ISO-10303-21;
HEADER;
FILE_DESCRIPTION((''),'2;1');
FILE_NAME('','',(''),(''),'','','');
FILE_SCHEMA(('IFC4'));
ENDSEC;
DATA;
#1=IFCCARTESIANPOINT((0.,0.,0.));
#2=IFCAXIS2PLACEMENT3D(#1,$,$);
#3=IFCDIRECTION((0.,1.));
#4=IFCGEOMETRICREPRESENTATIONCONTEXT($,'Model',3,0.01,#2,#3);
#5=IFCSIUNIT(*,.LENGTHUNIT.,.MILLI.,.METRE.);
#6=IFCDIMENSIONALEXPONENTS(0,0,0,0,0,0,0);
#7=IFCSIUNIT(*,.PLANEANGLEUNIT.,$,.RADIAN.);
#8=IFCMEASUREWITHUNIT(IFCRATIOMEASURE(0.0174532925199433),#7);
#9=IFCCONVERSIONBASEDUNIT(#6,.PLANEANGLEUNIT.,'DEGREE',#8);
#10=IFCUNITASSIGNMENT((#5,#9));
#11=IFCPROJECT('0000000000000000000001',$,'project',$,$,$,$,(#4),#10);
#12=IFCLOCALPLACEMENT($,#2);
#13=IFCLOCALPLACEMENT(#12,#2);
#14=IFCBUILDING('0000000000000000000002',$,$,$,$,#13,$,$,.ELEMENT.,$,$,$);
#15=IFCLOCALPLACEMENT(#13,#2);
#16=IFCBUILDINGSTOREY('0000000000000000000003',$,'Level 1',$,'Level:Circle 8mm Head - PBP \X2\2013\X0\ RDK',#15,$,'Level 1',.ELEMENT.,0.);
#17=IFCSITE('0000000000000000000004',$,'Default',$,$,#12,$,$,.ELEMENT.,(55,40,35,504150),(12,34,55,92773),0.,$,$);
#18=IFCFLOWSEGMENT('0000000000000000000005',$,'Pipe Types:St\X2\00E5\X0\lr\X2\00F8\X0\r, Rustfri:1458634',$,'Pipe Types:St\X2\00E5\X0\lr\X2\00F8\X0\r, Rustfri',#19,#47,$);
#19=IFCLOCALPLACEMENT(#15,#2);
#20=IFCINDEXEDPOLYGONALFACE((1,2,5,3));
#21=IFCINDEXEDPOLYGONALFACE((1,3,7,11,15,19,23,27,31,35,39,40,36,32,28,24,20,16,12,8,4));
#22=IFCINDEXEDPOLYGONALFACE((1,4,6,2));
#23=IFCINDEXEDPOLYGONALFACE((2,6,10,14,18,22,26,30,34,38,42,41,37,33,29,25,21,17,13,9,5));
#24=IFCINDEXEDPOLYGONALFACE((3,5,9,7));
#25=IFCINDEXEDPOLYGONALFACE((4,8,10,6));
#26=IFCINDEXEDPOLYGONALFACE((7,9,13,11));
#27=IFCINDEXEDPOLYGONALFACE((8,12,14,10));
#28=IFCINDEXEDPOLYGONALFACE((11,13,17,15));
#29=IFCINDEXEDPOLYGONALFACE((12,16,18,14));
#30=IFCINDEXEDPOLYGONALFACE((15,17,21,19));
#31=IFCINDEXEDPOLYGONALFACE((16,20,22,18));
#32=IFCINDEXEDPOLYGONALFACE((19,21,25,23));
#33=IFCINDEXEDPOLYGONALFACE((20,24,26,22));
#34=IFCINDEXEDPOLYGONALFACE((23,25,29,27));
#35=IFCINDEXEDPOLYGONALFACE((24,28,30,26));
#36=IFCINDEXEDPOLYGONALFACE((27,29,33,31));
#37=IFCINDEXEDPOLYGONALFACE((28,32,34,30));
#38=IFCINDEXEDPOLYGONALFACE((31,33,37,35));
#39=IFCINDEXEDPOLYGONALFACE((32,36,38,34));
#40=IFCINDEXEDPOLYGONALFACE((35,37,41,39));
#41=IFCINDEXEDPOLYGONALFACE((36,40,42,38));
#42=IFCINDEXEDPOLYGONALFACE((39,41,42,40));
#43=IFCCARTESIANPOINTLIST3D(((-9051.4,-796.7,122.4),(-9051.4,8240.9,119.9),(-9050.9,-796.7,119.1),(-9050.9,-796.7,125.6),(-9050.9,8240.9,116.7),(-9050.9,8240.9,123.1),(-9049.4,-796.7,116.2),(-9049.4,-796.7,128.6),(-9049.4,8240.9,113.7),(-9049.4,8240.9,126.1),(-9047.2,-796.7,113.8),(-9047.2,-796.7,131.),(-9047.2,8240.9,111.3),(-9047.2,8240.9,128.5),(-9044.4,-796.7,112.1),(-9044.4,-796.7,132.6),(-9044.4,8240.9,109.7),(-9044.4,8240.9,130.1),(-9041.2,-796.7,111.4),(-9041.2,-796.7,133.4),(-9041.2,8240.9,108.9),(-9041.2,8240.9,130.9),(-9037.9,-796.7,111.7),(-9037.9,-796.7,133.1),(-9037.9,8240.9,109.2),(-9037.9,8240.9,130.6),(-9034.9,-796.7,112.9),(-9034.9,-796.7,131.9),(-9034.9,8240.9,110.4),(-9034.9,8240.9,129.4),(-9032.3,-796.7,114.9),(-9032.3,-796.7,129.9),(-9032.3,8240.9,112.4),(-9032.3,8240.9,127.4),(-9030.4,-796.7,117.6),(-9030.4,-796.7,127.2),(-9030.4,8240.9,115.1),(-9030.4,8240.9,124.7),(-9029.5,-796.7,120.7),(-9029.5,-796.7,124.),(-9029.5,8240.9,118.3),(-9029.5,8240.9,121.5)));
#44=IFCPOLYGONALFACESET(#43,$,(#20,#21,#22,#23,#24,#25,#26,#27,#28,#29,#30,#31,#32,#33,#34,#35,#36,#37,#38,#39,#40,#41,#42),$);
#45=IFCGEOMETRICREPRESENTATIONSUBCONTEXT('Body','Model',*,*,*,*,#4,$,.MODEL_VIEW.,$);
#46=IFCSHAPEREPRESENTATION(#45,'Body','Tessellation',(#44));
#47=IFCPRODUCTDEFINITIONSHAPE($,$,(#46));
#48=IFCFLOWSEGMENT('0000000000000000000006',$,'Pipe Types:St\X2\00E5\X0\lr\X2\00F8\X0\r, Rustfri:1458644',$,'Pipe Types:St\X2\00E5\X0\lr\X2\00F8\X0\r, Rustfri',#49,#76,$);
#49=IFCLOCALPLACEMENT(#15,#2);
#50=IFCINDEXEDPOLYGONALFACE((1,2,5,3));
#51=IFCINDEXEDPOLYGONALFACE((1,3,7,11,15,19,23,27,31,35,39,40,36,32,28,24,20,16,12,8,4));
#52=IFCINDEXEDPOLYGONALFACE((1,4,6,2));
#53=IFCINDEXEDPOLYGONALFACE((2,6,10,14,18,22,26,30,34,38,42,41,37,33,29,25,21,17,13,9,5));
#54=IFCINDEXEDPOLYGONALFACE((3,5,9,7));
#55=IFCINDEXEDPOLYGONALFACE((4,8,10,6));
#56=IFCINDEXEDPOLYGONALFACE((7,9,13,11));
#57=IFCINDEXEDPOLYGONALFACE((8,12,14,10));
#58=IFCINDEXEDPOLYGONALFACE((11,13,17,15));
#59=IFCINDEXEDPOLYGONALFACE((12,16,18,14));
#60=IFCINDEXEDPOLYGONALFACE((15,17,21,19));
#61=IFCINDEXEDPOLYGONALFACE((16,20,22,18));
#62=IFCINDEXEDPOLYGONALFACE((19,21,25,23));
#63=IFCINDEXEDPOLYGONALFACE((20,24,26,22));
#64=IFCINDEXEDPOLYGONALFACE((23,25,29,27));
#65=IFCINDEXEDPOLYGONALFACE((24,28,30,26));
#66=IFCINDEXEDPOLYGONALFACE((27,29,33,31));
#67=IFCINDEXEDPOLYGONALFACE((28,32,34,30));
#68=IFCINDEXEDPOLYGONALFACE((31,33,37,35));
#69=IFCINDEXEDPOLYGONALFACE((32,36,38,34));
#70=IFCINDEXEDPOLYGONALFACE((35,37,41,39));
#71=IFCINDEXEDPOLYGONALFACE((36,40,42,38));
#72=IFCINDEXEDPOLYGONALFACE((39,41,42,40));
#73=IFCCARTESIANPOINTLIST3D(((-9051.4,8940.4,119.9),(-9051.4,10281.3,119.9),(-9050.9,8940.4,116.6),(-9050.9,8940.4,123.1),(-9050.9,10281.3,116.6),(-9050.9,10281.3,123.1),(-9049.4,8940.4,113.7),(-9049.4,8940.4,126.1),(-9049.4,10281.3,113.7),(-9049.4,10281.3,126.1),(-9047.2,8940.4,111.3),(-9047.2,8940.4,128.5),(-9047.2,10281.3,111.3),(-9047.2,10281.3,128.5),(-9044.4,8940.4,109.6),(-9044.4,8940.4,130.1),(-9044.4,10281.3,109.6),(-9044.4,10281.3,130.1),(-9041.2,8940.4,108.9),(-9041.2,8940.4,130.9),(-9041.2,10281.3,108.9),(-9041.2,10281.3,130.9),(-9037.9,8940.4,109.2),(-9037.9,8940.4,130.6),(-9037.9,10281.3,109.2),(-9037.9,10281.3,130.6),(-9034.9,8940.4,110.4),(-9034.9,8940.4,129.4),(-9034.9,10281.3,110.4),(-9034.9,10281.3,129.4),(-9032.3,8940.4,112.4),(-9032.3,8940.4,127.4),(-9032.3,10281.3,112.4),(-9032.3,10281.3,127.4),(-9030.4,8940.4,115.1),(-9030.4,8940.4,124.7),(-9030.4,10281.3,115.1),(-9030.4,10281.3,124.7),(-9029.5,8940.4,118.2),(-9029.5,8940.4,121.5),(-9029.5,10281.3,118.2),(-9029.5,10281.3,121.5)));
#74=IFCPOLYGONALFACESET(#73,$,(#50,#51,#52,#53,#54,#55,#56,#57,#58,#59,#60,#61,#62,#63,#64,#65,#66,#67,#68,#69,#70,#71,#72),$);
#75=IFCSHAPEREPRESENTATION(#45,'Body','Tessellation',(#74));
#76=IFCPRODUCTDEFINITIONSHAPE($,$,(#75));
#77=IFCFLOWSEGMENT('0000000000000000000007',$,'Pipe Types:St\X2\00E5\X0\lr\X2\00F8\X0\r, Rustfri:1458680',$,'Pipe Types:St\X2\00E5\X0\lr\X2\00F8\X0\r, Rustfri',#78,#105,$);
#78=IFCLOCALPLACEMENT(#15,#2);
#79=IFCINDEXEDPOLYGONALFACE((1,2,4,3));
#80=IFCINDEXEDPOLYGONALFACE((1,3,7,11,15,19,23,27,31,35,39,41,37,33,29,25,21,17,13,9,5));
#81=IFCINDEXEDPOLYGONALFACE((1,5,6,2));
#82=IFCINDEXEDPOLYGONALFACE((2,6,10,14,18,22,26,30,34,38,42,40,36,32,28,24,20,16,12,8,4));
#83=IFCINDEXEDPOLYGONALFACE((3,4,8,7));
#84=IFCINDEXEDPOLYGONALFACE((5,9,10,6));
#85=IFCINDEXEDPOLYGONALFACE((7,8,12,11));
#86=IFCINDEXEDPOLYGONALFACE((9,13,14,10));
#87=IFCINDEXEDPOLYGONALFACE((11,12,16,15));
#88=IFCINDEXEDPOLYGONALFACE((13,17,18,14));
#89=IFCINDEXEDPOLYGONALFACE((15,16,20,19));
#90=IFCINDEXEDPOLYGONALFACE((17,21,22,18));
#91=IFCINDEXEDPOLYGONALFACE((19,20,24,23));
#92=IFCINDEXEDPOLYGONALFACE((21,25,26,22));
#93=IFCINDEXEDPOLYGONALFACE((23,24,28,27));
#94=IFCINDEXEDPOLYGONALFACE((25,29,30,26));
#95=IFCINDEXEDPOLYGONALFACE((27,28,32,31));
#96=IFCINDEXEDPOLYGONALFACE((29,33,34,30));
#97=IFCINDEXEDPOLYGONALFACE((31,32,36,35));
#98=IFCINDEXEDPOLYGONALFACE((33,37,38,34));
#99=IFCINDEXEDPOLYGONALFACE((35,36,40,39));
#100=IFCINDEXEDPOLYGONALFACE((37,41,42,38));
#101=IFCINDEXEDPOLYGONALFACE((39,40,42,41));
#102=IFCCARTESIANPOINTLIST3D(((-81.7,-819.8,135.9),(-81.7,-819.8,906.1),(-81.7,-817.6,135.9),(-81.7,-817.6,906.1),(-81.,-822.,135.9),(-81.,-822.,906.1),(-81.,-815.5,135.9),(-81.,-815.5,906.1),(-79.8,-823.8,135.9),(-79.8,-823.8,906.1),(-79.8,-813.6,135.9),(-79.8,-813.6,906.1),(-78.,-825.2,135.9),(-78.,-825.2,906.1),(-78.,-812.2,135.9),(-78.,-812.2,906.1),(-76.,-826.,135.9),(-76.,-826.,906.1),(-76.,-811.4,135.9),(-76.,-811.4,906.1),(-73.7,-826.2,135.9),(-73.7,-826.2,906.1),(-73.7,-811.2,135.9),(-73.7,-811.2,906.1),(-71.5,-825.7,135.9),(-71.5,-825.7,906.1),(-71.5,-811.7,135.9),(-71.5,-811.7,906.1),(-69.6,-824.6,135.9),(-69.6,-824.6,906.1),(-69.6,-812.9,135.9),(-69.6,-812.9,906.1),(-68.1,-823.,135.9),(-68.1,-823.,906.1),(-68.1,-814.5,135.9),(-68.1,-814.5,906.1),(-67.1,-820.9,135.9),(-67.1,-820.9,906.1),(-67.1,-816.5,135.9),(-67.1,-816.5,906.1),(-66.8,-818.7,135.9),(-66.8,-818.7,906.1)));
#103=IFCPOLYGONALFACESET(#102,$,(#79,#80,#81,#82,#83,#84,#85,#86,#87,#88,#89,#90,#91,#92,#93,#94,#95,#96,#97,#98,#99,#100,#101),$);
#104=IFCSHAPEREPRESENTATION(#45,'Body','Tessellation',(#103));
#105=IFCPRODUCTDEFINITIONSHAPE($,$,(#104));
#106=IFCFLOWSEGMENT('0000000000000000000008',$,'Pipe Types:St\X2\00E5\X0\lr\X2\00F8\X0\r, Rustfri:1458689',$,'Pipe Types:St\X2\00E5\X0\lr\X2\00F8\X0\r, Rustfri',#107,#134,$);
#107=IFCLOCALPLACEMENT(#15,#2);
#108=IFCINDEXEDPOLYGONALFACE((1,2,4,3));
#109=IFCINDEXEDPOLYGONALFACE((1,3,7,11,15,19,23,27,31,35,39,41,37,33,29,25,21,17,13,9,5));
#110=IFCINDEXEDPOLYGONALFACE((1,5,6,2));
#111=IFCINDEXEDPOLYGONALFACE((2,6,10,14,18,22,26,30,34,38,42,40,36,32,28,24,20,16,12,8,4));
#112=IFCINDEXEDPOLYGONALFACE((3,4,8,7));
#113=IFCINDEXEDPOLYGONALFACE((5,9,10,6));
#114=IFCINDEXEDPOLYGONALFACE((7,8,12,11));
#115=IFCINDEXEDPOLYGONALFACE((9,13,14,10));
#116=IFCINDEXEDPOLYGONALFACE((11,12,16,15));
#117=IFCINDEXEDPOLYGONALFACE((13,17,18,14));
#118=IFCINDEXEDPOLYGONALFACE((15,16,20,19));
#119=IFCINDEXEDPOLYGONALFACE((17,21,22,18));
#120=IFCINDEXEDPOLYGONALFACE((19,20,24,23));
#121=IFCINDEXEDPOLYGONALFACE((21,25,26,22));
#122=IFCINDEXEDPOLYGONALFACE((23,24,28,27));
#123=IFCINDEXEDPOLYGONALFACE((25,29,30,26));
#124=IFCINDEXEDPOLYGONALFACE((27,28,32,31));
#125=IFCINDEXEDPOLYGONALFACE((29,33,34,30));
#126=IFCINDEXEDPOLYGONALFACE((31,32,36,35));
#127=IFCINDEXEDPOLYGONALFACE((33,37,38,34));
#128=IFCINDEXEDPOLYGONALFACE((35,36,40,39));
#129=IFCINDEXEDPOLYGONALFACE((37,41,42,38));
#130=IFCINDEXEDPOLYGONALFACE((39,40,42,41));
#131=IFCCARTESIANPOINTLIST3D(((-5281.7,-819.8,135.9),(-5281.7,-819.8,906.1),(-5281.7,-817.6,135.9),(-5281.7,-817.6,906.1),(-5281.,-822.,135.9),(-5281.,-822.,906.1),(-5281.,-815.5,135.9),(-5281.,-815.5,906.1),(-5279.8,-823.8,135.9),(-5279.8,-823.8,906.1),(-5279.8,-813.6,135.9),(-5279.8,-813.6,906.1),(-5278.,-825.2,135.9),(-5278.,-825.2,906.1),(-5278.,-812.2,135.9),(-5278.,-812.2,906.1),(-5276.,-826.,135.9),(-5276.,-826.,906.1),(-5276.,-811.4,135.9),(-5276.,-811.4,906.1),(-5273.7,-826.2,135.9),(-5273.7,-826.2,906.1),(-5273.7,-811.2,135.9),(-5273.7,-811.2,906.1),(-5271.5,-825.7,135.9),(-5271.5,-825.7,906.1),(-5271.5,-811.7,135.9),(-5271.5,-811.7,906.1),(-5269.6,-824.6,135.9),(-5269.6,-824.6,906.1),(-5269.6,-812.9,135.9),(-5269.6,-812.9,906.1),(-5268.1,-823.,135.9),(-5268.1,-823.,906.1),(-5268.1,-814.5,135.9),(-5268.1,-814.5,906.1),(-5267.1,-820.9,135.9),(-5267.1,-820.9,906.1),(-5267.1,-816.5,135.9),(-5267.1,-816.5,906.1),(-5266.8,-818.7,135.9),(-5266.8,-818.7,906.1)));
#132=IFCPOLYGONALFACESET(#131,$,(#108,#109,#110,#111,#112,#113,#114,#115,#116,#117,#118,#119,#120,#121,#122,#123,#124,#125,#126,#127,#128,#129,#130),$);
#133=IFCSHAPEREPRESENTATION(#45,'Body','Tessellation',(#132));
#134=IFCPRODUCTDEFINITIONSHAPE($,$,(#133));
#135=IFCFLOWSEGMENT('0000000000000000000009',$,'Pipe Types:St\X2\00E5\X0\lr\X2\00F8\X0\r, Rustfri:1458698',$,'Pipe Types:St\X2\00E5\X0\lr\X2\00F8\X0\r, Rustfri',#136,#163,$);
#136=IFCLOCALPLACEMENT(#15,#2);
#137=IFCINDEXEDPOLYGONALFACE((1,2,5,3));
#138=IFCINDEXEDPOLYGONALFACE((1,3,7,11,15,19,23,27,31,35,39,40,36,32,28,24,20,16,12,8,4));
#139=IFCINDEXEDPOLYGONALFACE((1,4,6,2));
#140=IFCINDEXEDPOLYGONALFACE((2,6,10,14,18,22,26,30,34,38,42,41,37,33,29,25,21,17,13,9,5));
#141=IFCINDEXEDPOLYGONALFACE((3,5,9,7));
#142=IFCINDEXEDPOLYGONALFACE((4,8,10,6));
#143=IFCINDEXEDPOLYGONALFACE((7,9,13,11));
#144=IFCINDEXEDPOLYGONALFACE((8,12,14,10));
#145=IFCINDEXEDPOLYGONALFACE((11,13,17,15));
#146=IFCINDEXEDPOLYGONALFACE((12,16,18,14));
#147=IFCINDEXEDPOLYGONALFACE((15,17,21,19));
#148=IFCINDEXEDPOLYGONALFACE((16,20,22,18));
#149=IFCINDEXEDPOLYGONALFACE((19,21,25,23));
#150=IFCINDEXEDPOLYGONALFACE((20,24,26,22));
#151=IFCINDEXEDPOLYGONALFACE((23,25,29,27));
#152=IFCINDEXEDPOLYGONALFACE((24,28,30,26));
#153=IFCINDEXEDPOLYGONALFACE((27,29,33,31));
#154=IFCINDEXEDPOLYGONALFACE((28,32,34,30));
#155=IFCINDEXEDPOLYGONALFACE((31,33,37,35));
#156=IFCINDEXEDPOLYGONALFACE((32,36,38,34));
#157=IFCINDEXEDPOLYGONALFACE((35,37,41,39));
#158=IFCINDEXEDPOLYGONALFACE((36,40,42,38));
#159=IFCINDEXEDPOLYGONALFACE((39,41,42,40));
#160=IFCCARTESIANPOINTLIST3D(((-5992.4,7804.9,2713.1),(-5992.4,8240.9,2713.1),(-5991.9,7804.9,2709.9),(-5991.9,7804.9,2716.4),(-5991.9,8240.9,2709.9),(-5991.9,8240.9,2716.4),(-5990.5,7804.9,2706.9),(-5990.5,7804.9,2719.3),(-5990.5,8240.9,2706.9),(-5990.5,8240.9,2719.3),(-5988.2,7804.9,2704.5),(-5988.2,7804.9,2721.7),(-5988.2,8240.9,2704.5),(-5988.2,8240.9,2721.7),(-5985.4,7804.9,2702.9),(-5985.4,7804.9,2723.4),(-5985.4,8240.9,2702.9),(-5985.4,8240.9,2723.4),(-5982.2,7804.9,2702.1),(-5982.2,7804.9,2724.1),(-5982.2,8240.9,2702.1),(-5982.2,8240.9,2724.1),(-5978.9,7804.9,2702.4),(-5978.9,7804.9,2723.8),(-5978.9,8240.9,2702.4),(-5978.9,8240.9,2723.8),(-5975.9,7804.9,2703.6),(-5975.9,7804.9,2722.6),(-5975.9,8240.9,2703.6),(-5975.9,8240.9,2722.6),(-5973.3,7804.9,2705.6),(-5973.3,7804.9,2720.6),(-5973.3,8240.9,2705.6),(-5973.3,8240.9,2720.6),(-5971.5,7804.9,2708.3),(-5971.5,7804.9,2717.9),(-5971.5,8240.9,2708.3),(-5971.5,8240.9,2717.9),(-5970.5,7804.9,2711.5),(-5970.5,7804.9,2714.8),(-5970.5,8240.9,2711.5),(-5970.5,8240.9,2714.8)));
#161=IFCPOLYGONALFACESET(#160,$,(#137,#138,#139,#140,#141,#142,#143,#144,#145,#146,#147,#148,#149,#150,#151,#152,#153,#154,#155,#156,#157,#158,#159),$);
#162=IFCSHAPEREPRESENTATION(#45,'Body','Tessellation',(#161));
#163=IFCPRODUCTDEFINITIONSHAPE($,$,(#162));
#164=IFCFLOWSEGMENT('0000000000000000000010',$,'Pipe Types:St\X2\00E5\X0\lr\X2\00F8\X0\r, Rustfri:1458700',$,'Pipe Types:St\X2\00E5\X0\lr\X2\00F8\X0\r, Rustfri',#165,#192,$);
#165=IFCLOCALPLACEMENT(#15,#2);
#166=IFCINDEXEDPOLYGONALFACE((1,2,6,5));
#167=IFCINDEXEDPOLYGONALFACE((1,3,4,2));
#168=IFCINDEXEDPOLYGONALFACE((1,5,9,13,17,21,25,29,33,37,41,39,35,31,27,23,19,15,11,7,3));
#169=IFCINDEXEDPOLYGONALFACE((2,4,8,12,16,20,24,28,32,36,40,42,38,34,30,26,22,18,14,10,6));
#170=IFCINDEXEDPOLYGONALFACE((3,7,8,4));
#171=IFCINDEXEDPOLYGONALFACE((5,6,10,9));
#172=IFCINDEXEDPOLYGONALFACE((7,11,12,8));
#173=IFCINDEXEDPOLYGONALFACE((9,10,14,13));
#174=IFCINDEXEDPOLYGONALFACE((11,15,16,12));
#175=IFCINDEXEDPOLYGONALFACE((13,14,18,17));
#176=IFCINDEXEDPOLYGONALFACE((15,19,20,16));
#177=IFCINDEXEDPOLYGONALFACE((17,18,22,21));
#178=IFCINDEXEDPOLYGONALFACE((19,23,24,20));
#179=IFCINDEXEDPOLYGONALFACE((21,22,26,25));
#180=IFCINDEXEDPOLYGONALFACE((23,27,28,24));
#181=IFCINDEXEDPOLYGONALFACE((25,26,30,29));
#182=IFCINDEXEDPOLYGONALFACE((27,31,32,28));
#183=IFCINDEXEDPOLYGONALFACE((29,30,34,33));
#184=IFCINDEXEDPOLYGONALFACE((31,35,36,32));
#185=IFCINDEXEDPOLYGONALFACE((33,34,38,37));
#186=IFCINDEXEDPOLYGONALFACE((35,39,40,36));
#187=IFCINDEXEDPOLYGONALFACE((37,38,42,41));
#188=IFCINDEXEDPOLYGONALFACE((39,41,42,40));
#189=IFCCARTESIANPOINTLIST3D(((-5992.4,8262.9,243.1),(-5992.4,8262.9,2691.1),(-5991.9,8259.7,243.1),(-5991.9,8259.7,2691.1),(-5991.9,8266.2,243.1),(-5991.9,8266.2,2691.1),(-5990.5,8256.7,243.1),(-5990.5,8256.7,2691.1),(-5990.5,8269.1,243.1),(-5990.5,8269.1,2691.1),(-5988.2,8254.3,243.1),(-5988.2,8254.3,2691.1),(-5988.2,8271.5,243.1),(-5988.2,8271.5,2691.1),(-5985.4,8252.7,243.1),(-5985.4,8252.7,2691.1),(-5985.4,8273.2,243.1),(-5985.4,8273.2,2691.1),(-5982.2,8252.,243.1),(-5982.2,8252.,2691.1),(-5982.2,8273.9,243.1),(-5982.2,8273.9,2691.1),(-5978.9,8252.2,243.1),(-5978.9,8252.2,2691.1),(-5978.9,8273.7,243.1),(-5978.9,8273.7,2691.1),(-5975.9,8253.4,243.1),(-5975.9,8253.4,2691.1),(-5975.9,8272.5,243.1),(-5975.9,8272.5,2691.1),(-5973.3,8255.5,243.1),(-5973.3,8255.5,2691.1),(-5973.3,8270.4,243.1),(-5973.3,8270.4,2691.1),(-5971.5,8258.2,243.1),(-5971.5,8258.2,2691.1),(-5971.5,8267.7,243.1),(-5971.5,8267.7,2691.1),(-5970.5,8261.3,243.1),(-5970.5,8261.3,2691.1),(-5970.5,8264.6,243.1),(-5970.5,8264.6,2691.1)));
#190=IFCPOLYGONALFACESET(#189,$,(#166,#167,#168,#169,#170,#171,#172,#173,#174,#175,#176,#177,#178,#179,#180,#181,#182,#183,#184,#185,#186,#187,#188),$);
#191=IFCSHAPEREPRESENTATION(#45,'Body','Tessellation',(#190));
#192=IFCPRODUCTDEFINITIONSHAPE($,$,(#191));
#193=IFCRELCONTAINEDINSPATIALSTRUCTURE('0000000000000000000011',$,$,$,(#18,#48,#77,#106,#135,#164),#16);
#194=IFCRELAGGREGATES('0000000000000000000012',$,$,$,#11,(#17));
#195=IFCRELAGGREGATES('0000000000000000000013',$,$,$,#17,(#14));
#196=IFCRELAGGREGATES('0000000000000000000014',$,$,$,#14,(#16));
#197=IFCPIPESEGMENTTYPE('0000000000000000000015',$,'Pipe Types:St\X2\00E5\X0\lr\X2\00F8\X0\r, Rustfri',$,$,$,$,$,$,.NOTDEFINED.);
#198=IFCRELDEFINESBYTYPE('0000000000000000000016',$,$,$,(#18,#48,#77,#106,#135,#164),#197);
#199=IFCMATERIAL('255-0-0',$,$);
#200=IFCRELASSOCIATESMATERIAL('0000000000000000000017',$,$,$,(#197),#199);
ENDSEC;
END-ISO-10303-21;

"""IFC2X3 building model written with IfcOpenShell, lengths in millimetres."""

from ifc_helpers import new_model, entity, si_unit, converted_unit, direction, frame, frame_2d, origin, origin_2d_with_axis, place, context, subcontext, project, spatial, circle, extrude, material, type_object, element, save


model = new_model("IFC2X3")

# Units and contexts
model_context = context("Model", 3, precision=0.01, world=origin(), true_north=direction((0.0, 1.0)))
body_context = subcontext(model_context, "Body", "Model", "MODEL_VIEW")
ifc_project = project(units=[si_unit("LENGTHUNIT", "METRE", prefix="MILLI"), converted_unit("PLANEANGLEUNIT", "DEGREE", entity("IfcRatioMeasure", 0.0174532925199433), si_unit("PLANEANGLEUNIT", "RADIAN"), dimensions=[0, 0, 0, 0, 0, 0, 0])], contexts=[model_context])

# Site, building, storey
site_placement = place(None, origin())
site = spatial("IfcSite", under=ifc_project, at=site_placement, Name="Default", CompositionType="ELEMENT", RefLatitude=(55, 40, 35, 504150), RefLongitude=(12, 34, 55, 92773), RefElevation=0.0)
building_placement = place(site_placement, origin())
building = spatial("IfcBuilding", under=site, at=building_placement, CompositionType="ELEMENT")
storey_placement = place(building_placement, origin())
storey = spatial("IfcBuildingStorey", under=building, at=storey_placement, Name="Level 1", ObjectType="Level:Circle 8mm Head - PBP – RDK", LongName="Level 1", CompositionType="ELEMENT", Elevation=0.0)

# Shared definitions
ifc_material_1 = material(Name="255-0-0")

# Flow segments
pipe_segment_type = type_object("IfcPipeSegmentType", Name="Pipe Types:Stålrør, Rustfri", PredefinedType="NOTDEFINED", material=ifc_material_1)
flow_segment_1_placement = place(storey_placement, origin())
element("IfcFlowSegment", 1, at=flow_segment_1_placement, inside=storey, type_object=pipe_segment_type, Name="Pipe Types:Stålrør, Rustfri:1458634", ObjectType="Pipe Types:Stålrør, Rustfri", context=body_context, shape_type="SweptSolid", body=[
    extrude(circle(Radius=11.0, at=frame_2d((0.0, 0.0), x_axis=(1.0, 0.0))), frame((-9040.4, 8240.9, 119.9), z_axis=(0.0, -1.0, 0.000275), x_axis=(-1.0, 0.0, 0.0)), (0.0, 0.0, 1.0), 9037.7),
])
flow_segment_2_placement = place(storey_placement, origin())
element("IfcFlowSegment", 2, at=flow_segment_2_placement, inside=storey, type_object=pipe_segment_type, Name="Pipe Types:Stålrør, Rustfri:1458644", ObjectType="Pipe Types:Stålrør, Rustfri", context=body_context, shape_type="SweptSolid", body=[
    extrude(circle(Radius=11.0, at=frame_2d((0.0, 0.0), x_axis=(1.0, 0.0))), frame((-9040.4, 8940.4, 119.9), z_axis=(0.0, 1.0, 0.0), x_axis=(-1.0, 0.0, 0.0)), (0.0, 0.0, 1.0), 1340.9),
])
flow_segment_3_placement = place(storey_placement, origin())
element("IfcFlowSegment", 3, at=flow_segment_3_placement, inside=storey, type_object=pipe_segment_type, Name="Pipe Types:Stålrør, Rustfri:1458680", ObjectType="Pipe Types:Stålrør, Rustfri", context=body_context, shape_type="SweptSolid", body=[
    extrude(circle(Radius=7.5, at=frame_2d((0.0, 0.0), x_axis=(1.0, 0.0))), frame((-74.3, -818.7, 135.9)), (0.0, 0.0, 1.0), 770.2),
])
flow_segment_4_placement = place(storey_placement, origin())
element("IfcFlowSegment", 4, at=flow_segment_4_placement, inside=storey, type_object=pipe_segment_type, Name="Pipe Types:Stålrør, Rustfri:1458689", ObjectType="Pipe Types:Stålrør, Rustfri", context=body_context, shape_type="SweptSolid", body=[
    extrude(circle(Radius=7.5, at=origin_2d_with_axis()), frame((-5274.3, -818.7, 135.9)), (0.0, 0.0, 1.0), 770.2),
])
flow_segment_5_placement = place(storey_placement, origin())
element("IfcFlowSegment", 5, at=flow_segment_5_placement, inside=storey, type_object=pipe_segment_type, Name="Pipe Types:Stålrør, Rustfri:1458698", ObjectType="Pipe Types:Stålrør, Rustfri", context=body_context, shape_type="SweptSolid", body=[
    extrude(circle(Radius=11.0, at=origin_2d_with_axis()), frame((-5981.4, 7804.9, 2713.1), z_axis=(0.0, 1.0, 0.0), x_axis=(-1.0, 0.0, 0.0)), (0.0, 0.0, 1.0), 436.0),
])
flow_segment_6_placement = place(storey_placement, origin())
element("IfcFlowSegment", 6, at=flow_segment_6_placement, inside=storey, type_object=pipe_segment_type, Name="Pipe Types:Stålrør, Rustfri:1458700", ObjectType="Pipe Types:Stålrør, Rustfri", context=body_context, shape_type="SweptSolid", body=[
    extrude(circle(Radius=11.0, at=frame_2d((0.0, 0.0), x_axis=(1.0, 0.0))), frame((-5981.4, 8262.9, 243.1), z_axis=(0.0, 0.0, 1.0), x_axis=(-1.0, 0.0, 0.0)), (0.0, 0.0, 1.0), 2448.0),
])

save(model, "model.ifc")
